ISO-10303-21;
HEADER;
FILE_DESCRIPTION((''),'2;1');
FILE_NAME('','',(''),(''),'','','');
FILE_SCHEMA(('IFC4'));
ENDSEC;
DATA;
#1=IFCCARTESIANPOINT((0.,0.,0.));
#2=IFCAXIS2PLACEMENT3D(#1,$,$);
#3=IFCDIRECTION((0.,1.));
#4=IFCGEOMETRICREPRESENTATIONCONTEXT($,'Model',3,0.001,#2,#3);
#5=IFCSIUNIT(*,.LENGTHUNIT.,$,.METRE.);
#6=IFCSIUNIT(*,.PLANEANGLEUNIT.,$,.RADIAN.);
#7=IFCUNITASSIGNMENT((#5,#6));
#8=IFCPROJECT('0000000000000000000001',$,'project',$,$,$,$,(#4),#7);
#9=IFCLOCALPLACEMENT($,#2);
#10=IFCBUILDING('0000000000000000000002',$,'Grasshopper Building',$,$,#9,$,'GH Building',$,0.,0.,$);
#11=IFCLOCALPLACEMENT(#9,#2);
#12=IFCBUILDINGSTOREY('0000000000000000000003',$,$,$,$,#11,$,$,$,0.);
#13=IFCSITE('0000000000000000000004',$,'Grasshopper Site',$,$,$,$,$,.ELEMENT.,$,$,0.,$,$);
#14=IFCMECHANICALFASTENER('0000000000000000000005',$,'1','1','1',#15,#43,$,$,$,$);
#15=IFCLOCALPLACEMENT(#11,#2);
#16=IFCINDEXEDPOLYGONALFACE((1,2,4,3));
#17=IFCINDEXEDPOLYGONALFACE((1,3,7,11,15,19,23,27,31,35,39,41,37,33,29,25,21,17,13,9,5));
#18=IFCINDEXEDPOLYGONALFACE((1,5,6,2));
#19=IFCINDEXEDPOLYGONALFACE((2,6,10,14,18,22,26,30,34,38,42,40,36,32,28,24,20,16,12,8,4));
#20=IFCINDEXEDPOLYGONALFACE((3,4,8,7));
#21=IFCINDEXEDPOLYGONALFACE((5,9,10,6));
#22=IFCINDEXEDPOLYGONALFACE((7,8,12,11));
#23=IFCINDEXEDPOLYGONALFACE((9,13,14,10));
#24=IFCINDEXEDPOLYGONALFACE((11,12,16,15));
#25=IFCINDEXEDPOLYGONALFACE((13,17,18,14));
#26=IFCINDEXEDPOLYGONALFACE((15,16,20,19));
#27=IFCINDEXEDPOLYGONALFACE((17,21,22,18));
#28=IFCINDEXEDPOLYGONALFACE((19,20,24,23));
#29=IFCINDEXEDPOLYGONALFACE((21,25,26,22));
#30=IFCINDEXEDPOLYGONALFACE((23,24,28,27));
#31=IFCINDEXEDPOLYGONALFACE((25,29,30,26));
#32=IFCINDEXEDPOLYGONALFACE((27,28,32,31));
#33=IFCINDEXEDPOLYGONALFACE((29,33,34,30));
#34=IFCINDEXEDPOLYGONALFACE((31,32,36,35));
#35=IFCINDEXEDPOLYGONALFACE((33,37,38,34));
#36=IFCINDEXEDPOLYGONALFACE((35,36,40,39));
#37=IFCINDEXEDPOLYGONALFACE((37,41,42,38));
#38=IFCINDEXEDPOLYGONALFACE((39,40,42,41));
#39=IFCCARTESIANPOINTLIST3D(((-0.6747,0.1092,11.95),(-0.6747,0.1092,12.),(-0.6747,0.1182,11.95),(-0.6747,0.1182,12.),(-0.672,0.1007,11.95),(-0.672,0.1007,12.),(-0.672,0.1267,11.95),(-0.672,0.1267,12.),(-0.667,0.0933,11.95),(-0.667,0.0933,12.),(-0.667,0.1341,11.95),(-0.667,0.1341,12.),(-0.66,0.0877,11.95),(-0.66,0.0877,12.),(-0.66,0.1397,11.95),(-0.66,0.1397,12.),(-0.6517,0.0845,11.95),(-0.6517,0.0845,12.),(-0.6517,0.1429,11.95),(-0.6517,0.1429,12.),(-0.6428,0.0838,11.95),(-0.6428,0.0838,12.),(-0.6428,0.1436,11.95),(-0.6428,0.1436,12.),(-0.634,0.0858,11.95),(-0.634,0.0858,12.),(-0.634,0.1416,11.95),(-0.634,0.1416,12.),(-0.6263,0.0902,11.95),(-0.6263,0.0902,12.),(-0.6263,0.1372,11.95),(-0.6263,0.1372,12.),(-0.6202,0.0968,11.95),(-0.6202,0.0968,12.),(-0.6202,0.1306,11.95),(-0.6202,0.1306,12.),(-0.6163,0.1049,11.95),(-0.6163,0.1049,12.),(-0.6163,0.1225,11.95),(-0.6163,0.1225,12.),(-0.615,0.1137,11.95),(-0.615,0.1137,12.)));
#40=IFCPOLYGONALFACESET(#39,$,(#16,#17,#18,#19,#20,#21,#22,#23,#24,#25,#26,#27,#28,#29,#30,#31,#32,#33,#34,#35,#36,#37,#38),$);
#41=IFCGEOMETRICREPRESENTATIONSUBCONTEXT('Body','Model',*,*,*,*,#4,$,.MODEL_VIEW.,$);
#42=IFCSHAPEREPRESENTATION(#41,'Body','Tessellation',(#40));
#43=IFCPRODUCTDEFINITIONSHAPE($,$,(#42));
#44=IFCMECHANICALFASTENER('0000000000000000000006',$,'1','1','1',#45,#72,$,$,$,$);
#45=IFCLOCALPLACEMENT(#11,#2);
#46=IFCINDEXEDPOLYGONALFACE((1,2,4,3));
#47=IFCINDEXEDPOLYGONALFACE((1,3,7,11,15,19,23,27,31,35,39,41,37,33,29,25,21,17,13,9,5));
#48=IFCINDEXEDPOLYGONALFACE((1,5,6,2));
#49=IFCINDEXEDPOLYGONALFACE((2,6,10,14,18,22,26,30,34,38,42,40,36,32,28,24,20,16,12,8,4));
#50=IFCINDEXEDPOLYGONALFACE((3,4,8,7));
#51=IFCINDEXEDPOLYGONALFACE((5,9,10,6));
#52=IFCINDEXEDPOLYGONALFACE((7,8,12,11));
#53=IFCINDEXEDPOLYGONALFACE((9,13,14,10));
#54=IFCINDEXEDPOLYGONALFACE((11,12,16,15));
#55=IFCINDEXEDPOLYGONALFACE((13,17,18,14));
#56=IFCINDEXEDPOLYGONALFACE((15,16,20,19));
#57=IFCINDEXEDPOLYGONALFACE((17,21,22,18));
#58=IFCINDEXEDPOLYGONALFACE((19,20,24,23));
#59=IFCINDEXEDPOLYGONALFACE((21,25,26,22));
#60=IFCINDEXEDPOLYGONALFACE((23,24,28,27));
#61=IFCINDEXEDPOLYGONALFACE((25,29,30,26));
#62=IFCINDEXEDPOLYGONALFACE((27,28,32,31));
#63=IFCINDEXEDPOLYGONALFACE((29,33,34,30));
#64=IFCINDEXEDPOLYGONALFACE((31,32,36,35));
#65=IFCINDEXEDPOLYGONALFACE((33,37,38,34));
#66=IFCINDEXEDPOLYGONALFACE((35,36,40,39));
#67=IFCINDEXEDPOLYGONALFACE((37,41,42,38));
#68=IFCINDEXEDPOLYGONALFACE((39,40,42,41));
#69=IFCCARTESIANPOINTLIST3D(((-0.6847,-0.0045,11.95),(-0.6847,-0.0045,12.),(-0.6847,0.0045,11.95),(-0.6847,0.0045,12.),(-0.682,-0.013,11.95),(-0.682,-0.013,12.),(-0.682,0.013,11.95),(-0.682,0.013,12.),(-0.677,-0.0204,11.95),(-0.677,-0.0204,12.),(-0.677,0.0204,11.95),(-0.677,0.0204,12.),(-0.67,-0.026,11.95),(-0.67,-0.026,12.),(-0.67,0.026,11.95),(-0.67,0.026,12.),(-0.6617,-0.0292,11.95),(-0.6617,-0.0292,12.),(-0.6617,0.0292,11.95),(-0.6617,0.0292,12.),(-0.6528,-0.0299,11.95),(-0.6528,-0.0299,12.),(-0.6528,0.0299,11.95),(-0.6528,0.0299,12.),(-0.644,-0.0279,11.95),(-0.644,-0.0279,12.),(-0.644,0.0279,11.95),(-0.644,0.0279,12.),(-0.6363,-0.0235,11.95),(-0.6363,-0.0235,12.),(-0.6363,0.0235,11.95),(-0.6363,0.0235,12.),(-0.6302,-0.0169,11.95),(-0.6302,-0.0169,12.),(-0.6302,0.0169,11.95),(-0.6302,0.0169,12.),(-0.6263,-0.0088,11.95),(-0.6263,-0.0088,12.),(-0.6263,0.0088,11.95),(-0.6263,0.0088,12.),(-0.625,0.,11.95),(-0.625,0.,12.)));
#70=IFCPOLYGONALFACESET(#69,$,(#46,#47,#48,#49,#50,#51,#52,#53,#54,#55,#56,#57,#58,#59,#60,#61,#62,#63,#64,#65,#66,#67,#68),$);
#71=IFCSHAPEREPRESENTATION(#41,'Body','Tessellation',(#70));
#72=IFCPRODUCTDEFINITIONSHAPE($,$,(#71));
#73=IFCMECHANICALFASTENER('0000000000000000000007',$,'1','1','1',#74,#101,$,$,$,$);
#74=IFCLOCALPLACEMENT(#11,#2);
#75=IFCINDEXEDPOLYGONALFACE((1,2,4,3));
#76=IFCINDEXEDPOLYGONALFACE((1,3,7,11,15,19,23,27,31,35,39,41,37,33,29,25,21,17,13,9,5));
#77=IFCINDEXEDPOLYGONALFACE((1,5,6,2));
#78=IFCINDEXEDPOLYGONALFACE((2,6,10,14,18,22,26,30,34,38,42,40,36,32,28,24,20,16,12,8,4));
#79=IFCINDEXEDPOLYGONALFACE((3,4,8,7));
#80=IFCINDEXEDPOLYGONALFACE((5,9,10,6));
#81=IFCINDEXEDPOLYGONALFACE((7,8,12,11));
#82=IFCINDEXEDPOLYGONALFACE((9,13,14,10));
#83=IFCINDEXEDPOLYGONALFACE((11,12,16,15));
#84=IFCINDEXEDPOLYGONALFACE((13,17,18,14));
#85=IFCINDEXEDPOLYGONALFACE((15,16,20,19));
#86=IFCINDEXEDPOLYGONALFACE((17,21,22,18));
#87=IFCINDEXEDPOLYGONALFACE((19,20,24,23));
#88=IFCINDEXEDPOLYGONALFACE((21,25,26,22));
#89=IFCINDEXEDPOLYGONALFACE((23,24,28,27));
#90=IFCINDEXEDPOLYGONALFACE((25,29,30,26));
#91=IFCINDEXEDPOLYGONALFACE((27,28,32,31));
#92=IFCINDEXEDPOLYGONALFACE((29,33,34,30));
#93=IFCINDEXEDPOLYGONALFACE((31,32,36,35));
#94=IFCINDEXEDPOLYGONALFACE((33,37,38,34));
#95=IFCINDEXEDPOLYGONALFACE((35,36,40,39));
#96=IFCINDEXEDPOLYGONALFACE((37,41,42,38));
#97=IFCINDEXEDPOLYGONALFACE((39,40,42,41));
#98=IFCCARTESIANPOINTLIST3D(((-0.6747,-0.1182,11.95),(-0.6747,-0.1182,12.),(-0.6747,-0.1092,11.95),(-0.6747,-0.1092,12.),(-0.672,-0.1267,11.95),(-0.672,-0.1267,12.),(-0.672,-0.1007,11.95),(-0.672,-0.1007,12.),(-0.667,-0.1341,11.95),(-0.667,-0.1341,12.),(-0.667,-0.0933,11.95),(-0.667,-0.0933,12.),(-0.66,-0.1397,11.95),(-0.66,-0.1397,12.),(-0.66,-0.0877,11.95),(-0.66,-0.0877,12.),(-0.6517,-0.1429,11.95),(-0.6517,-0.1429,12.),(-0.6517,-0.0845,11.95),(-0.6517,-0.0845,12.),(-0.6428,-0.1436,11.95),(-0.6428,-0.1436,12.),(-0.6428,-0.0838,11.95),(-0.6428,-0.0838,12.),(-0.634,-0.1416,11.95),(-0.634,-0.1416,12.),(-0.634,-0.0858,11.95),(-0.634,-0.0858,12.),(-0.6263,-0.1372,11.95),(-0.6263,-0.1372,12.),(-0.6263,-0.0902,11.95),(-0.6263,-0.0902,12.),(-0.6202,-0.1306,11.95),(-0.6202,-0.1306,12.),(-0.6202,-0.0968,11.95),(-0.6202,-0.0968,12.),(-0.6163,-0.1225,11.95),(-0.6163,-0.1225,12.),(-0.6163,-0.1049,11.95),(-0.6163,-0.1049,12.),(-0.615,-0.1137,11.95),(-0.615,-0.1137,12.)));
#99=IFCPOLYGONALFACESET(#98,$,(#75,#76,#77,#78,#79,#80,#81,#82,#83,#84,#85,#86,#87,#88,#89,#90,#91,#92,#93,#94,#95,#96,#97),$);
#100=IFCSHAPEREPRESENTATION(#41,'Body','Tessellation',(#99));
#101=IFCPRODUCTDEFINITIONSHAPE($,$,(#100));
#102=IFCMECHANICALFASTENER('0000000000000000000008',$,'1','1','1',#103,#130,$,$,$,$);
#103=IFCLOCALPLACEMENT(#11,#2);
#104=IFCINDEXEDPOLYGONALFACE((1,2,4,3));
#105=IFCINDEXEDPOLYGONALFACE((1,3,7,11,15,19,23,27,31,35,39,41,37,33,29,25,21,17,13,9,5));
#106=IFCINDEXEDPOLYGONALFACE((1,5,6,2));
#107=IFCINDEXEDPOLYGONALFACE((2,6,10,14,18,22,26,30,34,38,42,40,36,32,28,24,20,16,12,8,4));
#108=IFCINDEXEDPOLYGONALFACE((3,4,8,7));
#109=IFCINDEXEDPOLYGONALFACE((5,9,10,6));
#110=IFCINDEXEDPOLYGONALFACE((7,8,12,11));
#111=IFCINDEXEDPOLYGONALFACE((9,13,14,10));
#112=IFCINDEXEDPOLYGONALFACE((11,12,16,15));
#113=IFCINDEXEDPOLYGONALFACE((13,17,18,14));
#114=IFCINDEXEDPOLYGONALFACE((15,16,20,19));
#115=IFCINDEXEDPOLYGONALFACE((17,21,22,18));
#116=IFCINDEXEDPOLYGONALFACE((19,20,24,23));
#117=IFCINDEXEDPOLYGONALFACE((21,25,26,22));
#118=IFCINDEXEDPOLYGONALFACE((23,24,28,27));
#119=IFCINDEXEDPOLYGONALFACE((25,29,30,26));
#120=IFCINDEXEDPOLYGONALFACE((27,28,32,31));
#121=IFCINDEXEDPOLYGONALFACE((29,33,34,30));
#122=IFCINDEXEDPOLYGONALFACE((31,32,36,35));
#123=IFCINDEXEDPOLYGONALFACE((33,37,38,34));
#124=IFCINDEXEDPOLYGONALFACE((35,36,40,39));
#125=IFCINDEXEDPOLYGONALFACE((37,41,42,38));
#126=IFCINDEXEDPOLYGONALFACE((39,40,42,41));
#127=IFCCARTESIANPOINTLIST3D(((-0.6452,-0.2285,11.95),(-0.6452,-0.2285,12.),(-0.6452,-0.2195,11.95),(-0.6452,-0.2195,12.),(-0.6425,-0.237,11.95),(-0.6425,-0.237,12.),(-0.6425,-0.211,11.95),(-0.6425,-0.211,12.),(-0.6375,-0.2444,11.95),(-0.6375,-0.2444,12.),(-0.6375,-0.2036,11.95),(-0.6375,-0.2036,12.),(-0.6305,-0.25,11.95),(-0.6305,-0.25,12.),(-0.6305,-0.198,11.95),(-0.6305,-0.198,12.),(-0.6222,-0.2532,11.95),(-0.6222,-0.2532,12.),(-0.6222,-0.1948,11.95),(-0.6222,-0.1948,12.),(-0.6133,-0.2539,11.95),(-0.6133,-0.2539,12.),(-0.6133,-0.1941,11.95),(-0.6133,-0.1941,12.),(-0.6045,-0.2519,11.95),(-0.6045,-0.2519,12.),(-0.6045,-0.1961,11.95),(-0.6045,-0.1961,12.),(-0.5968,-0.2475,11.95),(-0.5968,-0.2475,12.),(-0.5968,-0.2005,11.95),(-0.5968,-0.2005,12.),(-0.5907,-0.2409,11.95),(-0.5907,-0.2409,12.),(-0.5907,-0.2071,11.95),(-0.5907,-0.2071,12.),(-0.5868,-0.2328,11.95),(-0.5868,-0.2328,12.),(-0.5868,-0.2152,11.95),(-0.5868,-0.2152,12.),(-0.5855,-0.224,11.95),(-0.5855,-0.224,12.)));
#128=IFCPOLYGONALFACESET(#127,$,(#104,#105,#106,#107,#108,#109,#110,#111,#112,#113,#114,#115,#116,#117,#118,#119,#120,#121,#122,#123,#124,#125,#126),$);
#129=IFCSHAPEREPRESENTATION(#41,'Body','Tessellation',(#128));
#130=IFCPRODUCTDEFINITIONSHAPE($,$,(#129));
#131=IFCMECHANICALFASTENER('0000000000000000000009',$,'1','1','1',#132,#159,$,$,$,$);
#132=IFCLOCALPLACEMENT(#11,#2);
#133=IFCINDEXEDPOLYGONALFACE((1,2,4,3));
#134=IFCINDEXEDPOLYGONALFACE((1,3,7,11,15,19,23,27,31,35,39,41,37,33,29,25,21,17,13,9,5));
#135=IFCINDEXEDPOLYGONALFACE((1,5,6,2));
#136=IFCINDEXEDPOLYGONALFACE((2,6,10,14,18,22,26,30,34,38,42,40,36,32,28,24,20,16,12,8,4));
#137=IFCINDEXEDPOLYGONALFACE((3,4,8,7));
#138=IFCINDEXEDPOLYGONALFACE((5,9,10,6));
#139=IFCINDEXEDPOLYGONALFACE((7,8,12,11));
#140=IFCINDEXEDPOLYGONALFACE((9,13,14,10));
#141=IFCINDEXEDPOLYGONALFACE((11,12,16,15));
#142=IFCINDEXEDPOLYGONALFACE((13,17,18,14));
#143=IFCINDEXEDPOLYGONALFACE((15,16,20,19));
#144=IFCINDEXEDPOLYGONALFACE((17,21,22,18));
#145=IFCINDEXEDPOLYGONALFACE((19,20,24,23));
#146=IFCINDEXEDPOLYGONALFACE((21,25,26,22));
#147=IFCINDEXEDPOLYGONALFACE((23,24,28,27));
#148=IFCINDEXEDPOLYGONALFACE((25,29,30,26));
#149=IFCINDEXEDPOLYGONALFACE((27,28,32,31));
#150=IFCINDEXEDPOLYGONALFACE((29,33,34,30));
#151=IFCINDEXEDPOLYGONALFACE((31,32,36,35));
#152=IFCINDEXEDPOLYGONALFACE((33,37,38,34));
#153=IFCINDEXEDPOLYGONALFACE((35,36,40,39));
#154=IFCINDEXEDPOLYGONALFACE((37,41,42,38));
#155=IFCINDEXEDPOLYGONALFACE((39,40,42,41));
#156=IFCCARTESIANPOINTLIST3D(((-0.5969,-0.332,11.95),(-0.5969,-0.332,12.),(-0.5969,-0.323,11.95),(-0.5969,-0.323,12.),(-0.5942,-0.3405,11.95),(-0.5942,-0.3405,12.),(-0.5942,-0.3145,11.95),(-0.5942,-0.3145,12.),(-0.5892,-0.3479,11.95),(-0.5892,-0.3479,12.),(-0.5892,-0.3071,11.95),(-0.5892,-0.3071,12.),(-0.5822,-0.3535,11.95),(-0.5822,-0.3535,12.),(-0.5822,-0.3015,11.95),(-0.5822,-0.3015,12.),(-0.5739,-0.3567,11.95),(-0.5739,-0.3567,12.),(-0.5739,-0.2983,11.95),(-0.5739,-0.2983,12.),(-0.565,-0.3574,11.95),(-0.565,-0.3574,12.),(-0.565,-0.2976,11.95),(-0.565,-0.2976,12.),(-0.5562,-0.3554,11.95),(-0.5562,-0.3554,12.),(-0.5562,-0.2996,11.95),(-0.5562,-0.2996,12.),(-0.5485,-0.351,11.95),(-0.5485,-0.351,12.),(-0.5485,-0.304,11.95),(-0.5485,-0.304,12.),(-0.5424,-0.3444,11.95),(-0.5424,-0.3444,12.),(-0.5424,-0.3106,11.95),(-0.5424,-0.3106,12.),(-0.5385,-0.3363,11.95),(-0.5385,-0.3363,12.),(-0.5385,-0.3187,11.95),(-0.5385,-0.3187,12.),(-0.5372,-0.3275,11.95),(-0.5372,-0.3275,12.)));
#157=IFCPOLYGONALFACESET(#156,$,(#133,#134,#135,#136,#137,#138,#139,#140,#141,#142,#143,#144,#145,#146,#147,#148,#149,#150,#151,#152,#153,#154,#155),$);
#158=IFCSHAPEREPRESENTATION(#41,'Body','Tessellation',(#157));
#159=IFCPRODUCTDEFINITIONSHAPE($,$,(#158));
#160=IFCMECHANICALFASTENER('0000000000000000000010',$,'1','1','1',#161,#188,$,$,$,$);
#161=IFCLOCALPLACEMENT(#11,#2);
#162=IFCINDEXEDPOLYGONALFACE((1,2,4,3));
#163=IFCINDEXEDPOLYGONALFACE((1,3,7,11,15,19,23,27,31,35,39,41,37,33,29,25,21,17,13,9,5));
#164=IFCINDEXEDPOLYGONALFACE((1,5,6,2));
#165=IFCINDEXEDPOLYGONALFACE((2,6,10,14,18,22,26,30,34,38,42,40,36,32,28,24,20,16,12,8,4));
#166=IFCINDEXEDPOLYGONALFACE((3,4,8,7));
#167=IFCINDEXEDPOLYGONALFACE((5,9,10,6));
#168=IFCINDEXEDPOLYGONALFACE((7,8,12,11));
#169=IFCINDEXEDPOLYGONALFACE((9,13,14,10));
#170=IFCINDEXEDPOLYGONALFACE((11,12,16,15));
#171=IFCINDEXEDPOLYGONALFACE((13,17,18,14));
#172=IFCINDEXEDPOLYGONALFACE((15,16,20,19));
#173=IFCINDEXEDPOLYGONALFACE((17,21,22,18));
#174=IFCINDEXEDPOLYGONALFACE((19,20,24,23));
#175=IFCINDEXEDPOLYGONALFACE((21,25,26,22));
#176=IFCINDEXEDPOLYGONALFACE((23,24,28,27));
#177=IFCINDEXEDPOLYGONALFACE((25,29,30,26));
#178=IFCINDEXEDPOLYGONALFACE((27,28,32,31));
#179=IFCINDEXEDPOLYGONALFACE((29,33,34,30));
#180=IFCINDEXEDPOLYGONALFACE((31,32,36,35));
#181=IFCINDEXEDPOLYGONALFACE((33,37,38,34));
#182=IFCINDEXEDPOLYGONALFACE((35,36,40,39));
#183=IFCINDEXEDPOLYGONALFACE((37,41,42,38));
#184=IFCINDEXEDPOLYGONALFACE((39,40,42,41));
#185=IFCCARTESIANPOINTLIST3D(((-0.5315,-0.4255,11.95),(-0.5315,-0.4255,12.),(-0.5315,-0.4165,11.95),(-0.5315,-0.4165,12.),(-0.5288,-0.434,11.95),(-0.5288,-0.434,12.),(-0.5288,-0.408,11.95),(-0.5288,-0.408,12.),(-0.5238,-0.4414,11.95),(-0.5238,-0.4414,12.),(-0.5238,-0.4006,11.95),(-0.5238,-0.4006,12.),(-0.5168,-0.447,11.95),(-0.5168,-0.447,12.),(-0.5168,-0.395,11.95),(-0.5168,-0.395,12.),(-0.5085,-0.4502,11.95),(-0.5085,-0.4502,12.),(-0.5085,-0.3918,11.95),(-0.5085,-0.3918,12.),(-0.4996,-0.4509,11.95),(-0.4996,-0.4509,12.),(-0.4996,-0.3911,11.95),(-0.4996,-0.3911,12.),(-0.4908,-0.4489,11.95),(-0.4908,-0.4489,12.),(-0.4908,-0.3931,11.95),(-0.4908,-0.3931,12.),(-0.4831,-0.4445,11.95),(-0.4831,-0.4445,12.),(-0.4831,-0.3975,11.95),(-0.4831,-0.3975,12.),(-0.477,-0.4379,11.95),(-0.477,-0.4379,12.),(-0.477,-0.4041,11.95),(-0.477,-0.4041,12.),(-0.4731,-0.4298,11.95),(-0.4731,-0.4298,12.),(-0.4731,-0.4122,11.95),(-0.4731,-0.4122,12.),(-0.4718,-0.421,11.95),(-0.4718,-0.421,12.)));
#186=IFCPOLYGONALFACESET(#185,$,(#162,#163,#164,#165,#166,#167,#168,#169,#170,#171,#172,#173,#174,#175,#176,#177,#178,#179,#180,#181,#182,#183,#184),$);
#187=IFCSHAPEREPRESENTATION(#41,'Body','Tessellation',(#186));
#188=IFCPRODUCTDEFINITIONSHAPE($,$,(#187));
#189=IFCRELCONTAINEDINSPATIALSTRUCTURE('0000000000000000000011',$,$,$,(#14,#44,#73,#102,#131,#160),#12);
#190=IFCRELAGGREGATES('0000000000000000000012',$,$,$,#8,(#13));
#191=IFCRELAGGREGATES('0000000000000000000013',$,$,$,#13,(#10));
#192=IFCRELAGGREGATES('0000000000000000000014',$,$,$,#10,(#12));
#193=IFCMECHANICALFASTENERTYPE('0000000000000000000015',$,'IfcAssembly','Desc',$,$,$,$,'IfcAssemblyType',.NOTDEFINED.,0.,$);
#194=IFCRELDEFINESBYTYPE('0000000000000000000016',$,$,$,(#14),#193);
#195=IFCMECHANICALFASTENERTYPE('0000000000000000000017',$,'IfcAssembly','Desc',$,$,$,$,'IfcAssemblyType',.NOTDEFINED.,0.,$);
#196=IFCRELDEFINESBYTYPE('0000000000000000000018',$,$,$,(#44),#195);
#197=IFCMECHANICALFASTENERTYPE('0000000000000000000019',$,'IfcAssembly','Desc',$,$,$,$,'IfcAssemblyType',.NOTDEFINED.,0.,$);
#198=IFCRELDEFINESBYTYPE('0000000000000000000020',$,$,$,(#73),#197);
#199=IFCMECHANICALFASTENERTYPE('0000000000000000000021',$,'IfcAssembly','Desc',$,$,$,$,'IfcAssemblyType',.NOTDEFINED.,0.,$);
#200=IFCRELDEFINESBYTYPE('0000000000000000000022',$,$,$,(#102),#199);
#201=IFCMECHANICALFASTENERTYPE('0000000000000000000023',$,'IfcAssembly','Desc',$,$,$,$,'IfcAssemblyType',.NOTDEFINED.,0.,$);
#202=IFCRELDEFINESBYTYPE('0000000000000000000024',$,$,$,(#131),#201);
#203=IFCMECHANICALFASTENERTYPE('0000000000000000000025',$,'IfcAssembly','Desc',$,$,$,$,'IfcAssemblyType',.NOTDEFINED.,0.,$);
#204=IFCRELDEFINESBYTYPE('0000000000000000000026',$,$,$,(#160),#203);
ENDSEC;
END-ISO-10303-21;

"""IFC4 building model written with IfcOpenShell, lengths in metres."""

from ifc_helpers import new_model, si_unit, direction, frame, origin, place, context, subcontext, project, spatial, circle, extrude, source, transform, mapped, type_object, type_shapes, element, save


model = new_model("IFC4")

# Units and contexts
model_context = context("Model", 3, precision=0.001, world=origin(), true_north=direction((0.0, 1.0)))
body_context = subcontext(model_context, "Body", "Model", "MODEL_VIEW")
ifc_project = project(units=[si_unit("LENGTHUNIT", "METRE"), si_unit("PLANEANGLEUNIT", "RADIAN")], contexts=[model_context])

# Site, building, storey
site = spatial("IfcSite", under=ifc_project, Name="Grasshopper Site", CompositionType="ELEMENT", RefElevation=0.0)
building_placement = place(None, origin())
building = spatial("IfcBuilding", under=site, at=building_placement, Name="Grasshopper Building", LongName="GH Building", ElevationOfRefHeight=0.0, ElevationOfTerrain=0.0)
storey_placement = place(building_placement, origin())
storey = spatial("IfcBuildingStorey", under=building, at=storey_placement, Elevation=0.0)

# Mechanical fasteners
mechanical_fastener_type_1 = type_object("IfcMechanicalFastenerType", Name="IfcAssembly", Description="Desc", ElementType="IfcAssemblyType", NominalDiameter=0.0)
shared_shape_1 = source(origin(), body_context, "Body", "SweptSolid", [
    extrude(circle(Radius=0.03), frame((-0.645, 0.1137, 12.0), z_axis=(0.0, 0.0, -1.0), x_axis=(1.0, 0.0, 0.0)), (0.0, 0.0, 1.0), 0.05),
])
type_shapes(mechanical_fastener_type_1, [shared_shape_1])
mechanical_fastener_1_placement = place(storey_placement, origin())
element("IfcMechanicalFastener", 1, at=mechanical_fastener_1_placement, inside=storey, type_object=mechanical_fastener_type_1, Name="1", Description="1", ObjectType="1", context=body_context, shape_type="MappedRepresentation", body=[
    mapped(shared_shape_1, transform((0.0, 0.0, 0.0), scale=1.0)),
])
mechanical_fastener_type_2 = type_object("IfcMechanicalFastenerType", Name="IfcAssembly", Description="Desc", ElementType="IfcAssemblyType", NominalDiameter=0.0)
shared_shape_2 = source(origin(), body_context, "Body", "SweptSolid", [
    extrude(circle(Radius=0.03), frame((-0.655, 0.0, 12.0), z_axis=(0.0, 0.0, -1.0), x_axis=(1.0, 0.0, 0.0)), (0.0, 0.0, 1.0), 0.05),
])
type_shapes(mechanical_fastener_type_2, [shared_shape_2])
mechanical_fastener_2_placement = place(storey_placement, origin())
element("IfcMechanicalFastener", 2, at=mechanical_fastener_2_placement, inside=storey, type_object=mechanical_fastener_type_2, Name="1", Description="1", ObjectType="1", context=body_context, shape_type="MappedRepresentation", body=[
    mapped(shared_shape_2, transform((0.0, 0.0, 0.0), scale=1.0)),
])
mechanical_fastener_type_3 = type_object("IfcMechanicalFastenerType", Name="IfcAssembly", Description="Desc", ElementType="IfcAssemblyType", NominalDiameter=0.0)
shared_shape_3 = source(origin(), body_context, "Body", "SweptSolid", [
    extrude(circle(Radius=0.03), frame((-0.645, -0.1137, 12.0), z_axis=(0.0, 0.0, -1.0), x_axis=(1.0, 0.0, 0.0)), (0.0, 0.0, 1.0), 0.05),
])
type_shapes(mechanical_fastener_type_3, [shared_shape_3])
mechanical_fastener_3_placement = place(storey_placement, origin())
element("IfcMechanicalFastener", 3, at=mechanical_fastener_3_placement, inside=storey, type_object=mechanical_fastener_type_3, Name="1", Description="1", ObjectType="1", context=body_context, shape_type="MappedRepresentation", body=[
    mapped(shared_shape_3, transform((0.0, 0.0, 0.0), scale=1.0)),
])
mechanical_fastener_type_4 = type_object("IfcMechanicalFastenerType", Name="IfcAssembly", Description="Desc", ElementType="IfcAssemblyType", NominalDiameter=0.0)
shared_shape_4 = source(origin(), body_context, "Body", "SweptSolid", [
    extrude(circle(Radius=0.03), frame((-0.6155, -0.224, 12.0), z_axis=(0.0, 0.0, -1.0), x_axis=(1.0, 0.0, 0.0)), (0.0, 0.0, 1.0), 0.05),
])
type_shapes(mechanical_fastener_type_4, [shared_shape_4])
mechanical_fastener_4_placement = place(storey_placement, origin())
element("IfcMechanicalFastener", 4, at=mechanical_fastener_4_placement, inside=storey, type_object=mechanical_fastener_type_4, Name="1", Description="1", ObjectType="1", context=body_context, shape_type="MappedRepresentation", body=[
    mapped(shared_shape_4, transform((0.0, 0.0, 0.0), scale=1.0)),
])
mechanical_fastener_type_5 = type_object("IfcMechanicalFastenerType", Name="IfcAssembly", Description="Desc", ElementType="IfcAssemblyType", NominalDiameter=0.0)
shared_shape_5 = source(origin(), body_context, "Body", "SweptSolid", [
    extrude(circle(Radius=0.03), frame((-0.5672, -0.3275, 12.0), z_axis=(0.0, 0.0, -1.0), x_axis=(1.0, 0.0, 0.0)), (0.0, 0.0, 1.0), 0.05),
])
type_shapes(mechanical_fastener_type_5, [shared_shape_5])
mechanical_fastener_5_placement = place(storey_placement, origin())
element("IfcMechanicalFastener", 5, at=mechanical_fastener_5_placement, inside=storey, type_object=mechanical_fastener_type_5, Name="1", Description="1", ObjectType="1", context=body_context, shape_type="MappedRepresentation", body=[
    mapped(shared_shape_5, transform((0.0, 0.0, 0.0), scale=1.0)),
])
mechanical_fastener_type_6 = type_object("IfcMechanicalFastenerType", Name="IfcAssembly", Description="Desc", ElementType="IfcAssemblyType", NominalDiameter=0.0)
shared_shape_6 = source(origin(), body_context, "Body", "SweptSolid", [
    extrude(circle(Radius=0.03), frame((-0.5018, -0.421, 12.0), z_axis=(0.0, 0.0, -1.0), x_axis=(1.0, 0.0, 0.0)), (0.0, 0.0, 1.0), 0.05),
])
type_shapes(mechanical_fastener_type_6, [shared_shape_6])
mechanical_fastener_6_placement = place(storey_placement, origin())
element("IfcMechanicalFastener", 6, at=mechanical_fastener_6_placement, inside=storey, type_object=mechanical_fastener_type_6, Name="1", Description="1", ObjectType="1", context=body_context, shape_type="MappedRepresentation", body=[
    mapped(shared_shape_6, transform((0.0, 0.0, 0.0), scale=1.0)),
])

save(model, "model.ifc")
